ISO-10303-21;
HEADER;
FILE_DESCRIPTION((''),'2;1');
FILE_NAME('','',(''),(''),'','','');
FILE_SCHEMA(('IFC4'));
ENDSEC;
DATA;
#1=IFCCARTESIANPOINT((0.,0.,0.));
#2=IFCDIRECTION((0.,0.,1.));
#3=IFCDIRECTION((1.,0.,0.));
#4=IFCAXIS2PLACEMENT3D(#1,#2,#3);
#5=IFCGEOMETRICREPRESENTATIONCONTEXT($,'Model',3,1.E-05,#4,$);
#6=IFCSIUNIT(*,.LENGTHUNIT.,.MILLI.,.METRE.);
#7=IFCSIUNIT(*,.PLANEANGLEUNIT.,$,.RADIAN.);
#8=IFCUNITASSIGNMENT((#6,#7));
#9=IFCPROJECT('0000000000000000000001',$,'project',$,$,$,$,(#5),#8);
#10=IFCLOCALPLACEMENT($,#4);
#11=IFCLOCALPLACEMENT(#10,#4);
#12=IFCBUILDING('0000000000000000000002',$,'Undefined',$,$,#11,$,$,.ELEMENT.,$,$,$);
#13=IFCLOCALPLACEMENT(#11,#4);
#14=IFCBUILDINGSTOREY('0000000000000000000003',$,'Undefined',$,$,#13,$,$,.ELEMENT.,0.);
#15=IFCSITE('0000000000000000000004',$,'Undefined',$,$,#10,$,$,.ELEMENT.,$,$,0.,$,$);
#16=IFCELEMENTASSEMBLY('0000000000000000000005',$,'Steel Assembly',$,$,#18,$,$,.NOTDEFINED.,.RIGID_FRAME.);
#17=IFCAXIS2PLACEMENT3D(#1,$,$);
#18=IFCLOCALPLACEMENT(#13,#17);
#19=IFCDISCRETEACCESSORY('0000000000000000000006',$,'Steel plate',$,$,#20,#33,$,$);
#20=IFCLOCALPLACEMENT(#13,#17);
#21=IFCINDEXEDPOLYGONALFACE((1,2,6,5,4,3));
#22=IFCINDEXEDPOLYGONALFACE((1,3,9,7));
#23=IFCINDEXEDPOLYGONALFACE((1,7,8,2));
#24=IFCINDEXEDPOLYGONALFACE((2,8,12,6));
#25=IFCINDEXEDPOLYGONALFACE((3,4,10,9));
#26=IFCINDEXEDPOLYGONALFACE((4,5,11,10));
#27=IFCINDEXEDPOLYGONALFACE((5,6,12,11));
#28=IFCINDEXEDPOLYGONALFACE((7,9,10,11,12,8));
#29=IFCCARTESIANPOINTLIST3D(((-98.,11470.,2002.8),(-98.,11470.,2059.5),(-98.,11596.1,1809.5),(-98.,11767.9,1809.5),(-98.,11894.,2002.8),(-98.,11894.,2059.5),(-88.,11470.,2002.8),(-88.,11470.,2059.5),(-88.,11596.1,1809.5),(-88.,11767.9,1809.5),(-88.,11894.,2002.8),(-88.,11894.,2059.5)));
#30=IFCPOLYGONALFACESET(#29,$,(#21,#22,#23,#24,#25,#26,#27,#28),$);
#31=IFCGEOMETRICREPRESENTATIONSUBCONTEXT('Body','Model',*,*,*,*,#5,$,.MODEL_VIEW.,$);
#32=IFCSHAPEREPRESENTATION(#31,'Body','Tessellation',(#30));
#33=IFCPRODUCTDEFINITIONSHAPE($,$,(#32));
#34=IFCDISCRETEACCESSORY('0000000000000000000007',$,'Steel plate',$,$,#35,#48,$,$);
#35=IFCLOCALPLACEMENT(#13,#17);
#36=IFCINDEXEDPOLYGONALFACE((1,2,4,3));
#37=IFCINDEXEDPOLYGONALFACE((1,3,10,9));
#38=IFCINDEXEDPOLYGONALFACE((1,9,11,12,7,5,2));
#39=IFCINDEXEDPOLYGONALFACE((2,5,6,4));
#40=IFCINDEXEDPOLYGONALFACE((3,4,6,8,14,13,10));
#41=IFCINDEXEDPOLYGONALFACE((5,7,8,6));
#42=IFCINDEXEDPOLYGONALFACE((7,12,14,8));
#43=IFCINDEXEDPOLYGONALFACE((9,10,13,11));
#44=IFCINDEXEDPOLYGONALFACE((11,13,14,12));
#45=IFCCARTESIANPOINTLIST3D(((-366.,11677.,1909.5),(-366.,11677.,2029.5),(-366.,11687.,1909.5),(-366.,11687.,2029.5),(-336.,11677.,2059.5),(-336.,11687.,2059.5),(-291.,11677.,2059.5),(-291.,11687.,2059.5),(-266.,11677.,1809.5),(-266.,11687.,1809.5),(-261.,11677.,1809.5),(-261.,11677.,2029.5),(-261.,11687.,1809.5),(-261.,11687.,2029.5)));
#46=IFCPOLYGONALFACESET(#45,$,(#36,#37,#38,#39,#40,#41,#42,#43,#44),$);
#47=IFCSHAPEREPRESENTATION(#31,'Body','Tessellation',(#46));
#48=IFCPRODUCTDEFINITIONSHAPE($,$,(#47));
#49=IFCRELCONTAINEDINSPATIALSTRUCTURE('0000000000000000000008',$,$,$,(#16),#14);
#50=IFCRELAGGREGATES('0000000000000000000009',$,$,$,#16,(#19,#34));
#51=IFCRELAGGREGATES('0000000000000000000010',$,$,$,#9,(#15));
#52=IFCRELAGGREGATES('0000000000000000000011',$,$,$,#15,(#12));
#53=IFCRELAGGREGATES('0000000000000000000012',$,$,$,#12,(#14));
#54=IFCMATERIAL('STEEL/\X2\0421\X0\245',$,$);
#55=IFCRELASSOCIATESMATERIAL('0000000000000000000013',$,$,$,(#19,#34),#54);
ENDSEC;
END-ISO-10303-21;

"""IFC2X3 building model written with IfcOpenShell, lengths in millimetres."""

from ifc_helpers import new_model, si_unit, frame, origin_with_axes, place, context, subcontext, project, spatial, polyline, outline, extrude, material, element, aggregate, save


model = new_model("IFC2X3")

# Units and contexts
model_context = context("Model", 3, precision=1e-05, world=origin_with_axes())
body_context = subcontext(model_context, "Body", "Model", "MODEL_VIEW")
ifc_project = project(units=[si_unit("LENGTHUNIT", "METRE", prefix="MILLI"), si_unit("PLANEANGLEUNIT", "RADIAN")], contexts=[model_context])

# Site, building, storey
site_placement = place(None, origin_with_axes())
site = spatial("IfcSite", under=ifc_project, at=site_placement, Name="Undefined", CompositionType="ELEMENT", RefElevation=0.0)
building_placement = place(site_placement, origin_with_axes())
building = spatial("IfcBuilding", under=site, at=building_placement, Name="Undefined", CompositionType="ELEMENT")
storey_placement = place(building_placement, origin_with_axes())
storey = spatial("IfcBuildingStorey", under=building, at=storey_placement, Name="Undefined", CompositionType="ELEMENT", Elevation=0.0)

# Element assembly
assembly_1_placement = place(storey_placement, origin_with_axes())
assembly_1 = element("IfcElementAssembly", 1, at=assembly_1_placement, inside=storey, Name="Steel Assembly", AssemblyPlace="NOTDEFINED", PredefinedType="RIGID_FRAME")
ifc_material_1 = material(Name="STEEL/С245")

# Discrete accessories
discrete_accessory_1_placement = place(assembly_1_placement, frame((-93.0, 11894.0, 2059.5), z_axis=(1.0, 0.0, 0.0), x_axis=(0.0, -1.0, 0.0)))
discrete_accessory_1 = element("IfcDiscreteAccessory", 2, at=discrete_accessory_1_placement, material=ifc_material_1, Name="Steel plate", context=body_context, shape_type="SweptSolid", body=[
    extrude(outline(polyline([(0.0, 0.0), (424.0, 0.0), (424.0, 56.7), (297.9, 250.0), (126.1, 250.0), (0.0, 56.7), (0.0, 0.0)])), frame((0.0, 0.0, -5.0), z_axis=(0.0, 0.0, 1.0), x_axis=(1.0, 0.0, 0.0)), (0.0, 0.0, 1.0), 10.0),
])
discrete_accessory_2_placement = place(assembly_1_placement, frame((-261.0, 11682.0, 2059.5), z_axis=(0.0, -1.0, 0.0), x_axis=(-1.0, 0.0, 0.0)))
discrete_accessory_2 = element("IfcDiscreteAccessory", 3, at=discrete_accessory_2_placement, material=ifc_material_1, Name="Steel plate", context=body_context, shape_type="SweptSolid", body=[
    extrude(outline(polyline([(0.0, 30.0), (30.0, 0.0), (75.0, 0.0), (105.0, 30.0), (105.0, 150.0), (5.0, 250.0), (0.0, 250.0), (0.0, 30.0)])), frame((0.0, 0.0, -5.0), z_axis=(0.0, 0.0, 1.0), x_axis=(1.0, 0.0, 0.0)), (0.0, 0.0, 1.0), 10.0),
])
aggregate(assembly_1, [discrete_accessory_1, discrete_accessory_2])

save(model, "model.ifc")
